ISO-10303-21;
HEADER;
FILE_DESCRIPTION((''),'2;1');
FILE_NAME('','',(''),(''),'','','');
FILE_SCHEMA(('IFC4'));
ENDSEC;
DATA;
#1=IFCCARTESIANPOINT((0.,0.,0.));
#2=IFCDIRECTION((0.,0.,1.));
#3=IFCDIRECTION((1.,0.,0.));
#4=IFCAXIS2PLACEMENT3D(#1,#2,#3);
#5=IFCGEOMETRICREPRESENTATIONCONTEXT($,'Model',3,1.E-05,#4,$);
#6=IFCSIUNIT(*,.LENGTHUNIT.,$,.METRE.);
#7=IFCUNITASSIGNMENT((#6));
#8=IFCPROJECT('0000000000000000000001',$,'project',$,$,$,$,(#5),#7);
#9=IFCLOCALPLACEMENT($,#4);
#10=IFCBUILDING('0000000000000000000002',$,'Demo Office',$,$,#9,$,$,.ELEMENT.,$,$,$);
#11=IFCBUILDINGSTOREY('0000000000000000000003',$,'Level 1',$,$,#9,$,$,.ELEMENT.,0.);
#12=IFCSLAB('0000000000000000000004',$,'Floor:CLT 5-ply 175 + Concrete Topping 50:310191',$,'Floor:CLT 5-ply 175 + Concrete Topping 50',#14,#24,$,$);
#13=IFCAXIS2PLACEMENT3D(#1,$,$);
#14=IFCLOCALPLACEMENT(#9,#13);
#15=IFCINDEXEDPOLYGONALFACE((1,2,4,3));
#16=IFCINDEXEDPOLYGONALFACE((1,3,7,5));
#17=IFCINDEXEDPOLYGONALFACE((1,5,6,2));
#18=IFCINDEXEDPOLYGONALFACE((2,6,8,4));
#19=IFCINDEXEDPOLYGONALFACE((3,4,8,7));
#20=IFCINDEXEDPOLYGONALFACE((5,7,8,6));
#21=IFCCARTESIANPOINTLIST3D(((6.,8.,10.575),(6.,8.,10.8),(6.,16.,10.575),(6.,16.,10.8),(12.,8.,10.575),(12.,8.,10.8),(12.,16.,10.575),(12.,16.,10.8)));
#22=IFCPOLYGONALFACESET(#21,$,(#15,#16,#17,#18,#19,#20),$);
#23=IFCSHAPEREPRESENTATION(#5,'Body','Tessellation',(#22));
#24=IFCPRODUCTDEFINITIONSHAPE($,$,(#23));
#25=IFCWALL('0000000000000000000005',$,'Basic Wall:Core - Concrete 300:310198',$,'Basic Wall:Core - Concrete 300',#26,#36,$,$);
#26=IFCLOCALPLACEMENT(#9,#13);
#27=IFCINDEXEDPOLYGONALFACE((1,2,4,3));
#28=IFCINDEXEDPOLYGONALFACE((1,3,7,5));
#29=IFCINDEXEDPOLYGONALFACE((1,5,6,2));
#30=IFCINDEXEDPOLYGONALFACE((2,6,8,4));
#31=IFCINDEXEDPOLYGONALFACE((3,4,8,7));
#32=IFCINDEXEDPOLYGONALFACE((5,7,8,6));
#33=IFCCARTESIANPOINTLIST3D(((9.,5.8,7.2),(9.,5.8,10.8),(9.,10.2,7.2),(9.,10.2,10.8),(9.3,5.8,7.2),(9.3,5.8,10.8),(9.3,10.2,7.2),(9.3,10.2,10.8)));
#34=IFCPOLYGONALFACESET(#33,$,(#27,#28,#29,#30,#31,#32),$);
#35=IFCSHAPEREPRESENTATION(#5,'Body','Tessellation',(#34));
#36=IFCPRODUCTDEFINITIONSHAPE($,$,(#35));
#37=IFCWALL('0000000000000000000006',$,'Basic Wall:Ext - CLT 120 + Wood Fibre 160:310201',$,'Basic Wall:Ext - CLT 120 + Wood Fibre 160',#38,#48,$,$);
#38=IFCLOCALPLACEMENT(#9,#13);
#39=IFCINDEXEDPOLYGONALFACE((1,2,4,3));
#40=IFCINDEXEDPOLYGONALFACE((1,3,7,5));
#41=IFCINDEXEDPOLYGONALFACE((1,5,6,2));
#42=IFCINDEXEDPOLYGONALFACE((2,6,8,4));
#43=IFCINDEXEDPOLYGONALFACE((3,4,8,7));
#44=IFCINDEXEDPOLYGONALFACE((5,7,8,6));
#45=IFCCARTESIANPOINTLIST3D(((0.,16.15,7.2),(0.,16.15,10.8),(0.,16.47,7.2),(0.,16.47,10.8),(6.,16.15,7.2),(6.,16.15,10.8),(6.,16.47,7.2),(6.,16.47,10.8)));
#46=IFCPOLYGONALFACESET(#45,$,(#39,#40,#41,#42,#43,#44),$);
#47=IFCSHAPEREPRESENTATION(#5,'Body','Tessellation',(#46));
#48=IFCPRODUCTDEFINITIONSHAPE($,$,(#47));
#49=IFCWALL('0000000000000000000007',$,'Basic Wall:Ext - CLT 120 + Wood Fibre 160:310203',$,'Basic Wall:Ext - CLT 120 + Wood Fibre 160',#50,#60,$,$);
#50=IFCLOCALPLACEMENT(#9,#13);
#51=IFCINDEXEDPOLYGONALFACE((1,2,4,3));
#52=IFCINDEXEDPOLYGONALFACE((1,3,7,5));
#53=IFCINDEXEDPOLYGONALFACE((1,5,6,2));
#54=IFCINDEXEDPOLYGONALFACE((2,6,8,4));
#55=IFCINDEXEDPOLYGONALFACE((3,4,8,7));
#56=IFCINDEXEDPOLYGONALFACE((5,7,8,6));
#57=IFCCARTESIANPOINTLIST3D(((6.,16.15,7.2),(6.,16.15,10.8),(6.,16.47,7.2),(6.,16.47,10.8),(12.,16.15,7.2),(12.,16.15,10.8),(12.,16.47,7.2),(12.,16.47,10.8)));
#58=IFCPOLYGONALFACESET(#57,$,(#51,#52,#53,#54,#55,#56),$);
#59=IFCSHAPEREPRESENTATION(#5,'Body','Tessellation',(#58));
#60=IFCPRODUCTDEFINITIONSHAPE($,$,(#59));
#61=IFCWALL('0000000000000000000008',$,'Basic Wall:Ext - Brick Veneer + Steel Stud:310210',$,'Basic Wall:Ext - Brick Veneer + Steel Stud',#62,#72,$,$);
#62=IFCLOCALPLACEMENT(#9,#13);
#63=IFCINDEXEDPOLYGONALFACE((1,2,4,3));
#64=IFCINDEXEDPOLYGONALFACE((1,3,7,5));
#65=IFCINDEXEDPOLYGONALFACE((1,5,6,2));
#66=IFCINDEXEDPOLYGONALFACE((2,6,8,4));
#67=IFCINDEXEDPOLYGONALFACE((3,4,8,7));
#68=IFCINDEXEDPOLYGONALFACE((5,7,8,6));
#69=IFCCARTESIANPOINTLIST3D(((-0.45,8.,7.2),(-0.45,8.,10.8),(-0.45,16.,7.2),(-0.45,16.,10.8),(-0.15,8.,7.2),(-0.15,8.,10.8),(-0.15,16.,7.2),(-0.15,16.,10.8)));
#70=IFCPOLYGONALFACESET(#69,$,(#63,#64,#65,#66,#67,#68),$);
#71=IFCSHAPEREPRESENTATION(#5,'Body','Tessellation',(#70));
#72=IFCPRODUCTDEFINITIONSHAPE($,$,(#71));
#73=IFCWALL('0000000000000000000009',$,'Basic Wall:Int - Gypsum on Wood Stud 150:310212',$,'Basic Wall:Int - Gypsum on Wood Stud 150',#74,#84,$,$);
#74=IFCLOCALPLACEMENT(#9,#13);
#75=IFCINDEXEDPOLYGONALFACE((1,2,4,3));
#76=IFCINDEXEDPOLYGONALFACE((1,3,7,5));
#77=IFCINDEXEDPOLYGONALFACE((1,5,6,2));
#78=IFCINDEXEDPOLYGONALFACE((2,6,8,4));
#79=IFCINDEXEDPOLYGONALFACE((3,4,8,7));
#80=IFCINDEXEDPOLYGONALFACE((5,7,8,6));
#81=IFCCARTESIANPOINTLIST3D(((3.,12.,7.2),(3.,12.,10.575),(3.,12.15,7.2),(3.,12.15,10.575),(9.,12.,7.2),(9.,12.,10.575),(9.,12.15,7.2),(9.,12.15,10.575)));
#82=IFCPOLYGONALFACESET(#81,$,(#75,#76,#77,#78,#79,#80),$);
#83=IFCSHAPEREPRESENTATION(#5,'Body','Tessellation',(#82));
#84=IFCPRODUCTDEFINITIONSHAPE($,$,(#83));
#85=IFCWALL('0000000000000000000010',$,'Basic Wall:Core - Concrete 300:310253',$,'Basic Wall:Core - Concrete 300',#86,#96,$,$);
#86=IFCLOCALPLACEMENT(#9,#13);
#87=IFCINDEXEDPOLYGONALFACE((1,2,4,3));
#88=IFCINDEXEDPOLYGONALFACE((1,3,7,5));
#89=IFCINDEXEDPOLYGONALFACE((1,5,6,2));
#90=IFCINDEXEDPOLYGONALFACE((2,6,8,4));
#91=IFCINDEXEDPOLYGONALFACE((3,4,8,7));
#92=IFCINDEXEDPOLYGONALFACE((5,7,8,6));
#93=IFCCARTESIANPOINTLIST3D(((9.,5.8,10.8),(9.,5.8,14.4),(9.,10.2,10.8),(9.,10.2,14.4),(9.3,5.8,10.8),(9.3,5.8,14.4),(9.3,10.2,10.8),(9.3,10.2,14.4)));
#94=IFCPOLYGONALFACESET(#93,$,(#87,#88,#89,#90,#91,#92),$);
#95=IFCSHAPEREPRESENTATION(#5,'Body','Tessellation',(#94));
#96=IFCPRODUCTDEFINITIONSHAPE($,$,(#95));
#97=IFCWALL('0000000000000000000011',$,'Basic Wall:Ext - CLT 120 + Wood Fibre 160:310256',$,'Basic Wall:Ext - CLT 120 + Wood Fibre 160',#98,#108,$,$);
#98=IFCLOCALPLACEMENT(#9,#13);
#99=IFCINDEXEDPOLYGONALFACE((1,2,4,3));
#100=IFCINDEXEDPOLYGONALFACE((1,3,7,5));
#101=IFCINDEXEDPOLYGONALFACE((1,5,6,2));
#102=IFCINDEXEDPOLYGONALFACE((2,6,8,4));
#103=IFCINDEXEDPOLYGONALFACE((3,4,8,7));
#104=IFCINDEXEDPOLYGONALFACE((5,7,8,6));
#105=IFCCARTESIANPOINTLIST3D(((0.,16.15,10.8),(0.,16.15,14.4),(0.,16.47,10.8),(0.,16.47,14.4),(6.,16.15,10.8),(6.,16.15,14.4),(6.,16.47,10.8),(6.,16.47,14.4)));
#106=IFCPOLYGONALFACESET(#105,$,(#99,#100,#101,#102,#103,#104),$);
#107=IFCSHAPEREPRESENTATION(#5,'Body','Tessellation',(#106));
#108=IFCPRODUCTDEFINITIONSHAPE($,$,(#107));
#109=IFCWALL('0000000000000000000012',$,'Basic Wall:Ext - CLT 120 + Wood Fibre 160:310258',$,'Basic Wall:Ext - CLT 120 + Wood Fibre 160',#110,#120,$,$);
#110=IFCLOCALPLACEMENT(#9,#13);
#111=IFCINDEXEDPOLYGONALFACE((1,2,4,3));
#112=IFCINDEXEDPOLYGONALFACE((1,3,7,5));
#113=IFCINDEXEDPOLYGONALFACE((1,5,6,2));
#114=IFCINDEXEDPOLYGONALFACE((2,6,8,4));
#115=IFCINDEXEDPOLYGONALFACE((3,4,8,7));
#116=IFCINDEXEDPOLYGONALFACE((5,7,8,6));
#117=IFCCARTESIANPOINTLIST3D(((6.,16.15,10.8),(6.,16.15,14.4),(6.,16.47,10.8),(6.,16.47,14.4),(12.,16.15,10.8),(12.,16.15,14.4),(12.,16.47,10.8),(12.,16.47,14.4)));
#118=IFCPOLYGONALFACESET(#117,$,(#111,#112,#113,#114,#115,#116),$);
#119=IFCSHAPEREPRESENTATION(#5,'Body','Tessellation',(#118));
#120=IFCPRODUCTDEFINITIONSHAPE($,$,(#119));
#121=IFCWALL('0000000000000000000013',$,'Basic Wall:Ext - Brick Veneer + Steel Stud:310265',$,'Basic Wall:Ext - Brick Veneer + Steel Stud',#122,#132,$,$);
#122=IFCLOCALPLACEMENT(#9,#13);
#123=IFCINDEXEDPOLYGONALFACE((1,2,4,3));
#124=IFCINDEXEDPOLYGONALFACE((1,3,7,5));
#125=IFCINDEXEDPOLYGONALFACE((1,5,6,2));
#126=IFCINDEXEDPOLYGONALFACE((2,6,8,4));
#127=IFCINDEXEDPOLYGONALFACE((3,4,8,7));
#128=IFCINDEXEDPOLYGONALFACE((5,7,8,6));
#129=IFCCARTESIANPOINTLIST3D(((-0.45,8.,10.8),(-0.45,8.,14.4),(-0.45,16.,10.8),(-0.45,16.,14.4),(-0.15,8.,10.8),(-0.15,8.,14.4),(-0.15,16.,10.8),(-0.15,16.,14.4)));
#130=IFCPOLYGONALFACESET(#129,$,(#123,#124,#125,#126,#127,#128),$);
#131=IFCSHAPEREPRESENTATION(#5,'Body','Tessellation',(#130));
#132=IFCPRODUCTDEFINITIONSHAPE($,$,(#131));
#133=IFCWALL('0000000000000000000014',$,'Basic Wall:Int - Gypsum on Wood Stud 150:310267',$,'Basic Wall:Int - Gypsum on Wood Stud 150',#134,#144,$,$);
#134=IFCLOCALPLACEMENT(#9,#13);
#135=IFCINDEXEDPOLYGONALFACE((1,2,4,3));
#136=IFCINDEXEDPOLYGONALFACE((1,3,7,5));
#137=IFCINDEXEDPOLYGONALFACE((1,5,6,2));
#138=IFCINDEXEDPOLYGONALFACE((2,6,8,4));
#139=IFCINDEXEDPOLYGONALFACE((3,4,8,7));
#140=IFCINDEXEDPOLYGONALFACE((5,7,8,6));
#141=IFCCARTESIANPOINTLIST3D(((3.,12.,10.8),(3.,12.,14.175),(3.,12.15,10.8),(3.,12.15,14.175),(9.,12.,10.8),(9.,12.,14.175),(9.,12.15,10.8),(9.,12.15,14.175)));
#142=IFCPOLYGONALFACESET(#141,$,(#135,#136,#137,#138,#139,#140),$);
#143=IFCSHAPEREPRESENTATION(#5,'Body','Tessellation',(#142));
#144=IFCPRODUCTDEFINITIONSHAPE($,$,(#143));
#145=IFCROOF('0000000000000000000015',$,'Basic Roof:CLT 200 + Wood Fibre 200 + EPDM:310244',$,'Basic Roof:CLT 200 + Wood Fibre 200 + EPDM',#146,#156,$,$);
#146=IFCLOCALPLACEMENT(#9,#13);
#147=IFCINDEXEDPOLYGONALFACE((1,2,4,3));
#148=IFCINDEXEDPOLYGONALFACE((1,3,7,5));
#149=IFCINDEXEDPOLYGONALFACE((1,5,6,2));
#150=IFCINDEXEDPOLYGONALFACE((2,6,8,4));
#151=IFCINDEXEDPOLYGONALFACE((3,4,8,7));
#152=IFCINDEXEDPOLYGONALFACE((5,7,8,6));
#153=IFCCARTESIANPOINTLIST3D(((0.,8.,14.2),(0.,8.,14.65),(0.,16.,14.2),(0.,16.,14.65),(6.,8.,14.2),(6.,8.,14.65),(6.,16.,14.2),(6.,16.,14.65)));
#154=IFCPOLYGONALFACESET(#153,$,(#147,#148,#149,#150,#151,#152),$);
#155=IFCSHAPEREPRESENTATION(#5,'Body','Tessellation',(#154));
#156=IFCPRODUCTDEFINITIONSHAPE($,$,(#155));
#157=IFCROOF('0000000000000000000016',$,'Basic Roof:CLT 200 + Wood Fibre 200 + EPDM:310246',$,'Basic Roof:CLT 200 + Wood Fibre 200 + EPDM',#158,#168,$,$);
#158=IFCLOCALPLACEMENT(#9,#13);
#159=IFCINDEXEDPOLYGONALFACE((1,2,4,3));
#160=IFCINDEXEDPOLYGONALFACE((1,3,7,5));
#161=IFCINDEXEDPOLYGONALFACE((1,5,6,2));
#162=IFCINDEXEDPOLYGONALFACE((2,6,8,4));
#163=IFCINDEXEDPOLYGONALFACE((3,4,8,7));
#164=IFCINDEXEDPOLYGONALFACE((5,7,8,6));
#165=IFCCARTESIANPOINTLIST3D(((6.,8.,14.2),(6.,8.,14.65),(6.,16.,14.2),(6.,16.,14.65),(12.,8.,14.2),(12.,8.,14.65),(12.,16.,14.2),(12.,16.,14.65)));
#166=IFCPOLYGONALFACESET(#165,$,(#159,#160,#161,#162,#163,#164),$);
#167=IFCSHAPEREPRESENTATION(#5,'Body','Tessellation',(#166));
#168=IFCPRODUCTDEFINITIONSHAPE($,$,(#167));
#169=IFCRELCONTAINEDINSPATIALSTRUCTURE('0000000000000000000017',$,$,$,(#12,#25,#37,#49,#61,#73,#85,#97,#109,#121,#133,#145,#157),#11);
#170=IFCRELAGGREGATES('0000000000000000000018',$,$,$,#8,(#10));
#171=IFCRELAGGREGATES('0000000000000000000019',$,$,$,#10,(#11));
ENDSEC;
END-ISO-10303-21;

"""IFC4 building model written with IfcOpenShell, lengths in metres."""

from ifc_helpers import new_model, si_unit, frame, origin_with_axes, origin_2d, place, context, project, spatial, rectangle, extrude, element, save


model = new_model("IFC4")

# Units and contexts
model_context = context("Model", 3, precision=1e-05, world=origin_with_axes())
ifc_project = project(units=[si_unit("LENGTHUNIT", "METRE")], contexts=[model_context])

# Building, storey
placement = place(None, origin_with_axes())
building = spatial("IfcBuilding", under=ifc_project, at=placement, Name="Demo Office", CompositionType="ELEMENT")
storey = spatial("IfcBuildingStorey", under=building, at=placement, Name="Level 1", CompositionType="ELEMENT", Elevation=0.0)

# Slab
for number, where, name in (
    (1, (9.0, 12.0, 10.575), "Floor:CLT 5-ply 175 + Concrete Topping 50:310191"),
):
    element("IfcSlab", number, at=place(placement, frame(where)), inside=storey, Name=name, ObjectType="Floor:CLT 5-ply 175 + Concrete Topping 50", context=model_context, shape_type="SweptSolid", body=[
        extrude(rectangle(XDim=6.0, YDim=8.0, at=origin_2d()), origin_with_axes(), (0.0, 0.0, 1.0), 0.225),
    ])

# Walls
wall_1_placement = place(placement, frame((9.15, 8.0, 7.2)))
element("IfcWall", 2, at=wall_1_placement, inside=storey, Name="Basic Wall:Core - Concrete 300:310198", ObjectType="Basic Wall:Core - Concrete 300", context=model_context, shape_type="SweptSolid", body=[
    extrude(rectangle(XDim=0.3, YDim=4.4, at=origin_2d()), origin_with_axes(), (0.0, 0.0, 1.0), 3.6),
])
for number, where, name in (
    (3, (3.0, 16.31, 7.2), "Basic Wall:Ext - CLT 120 + Wood Fibre 160:310201"),
    (4, (9.0, 16.31, 7.2), "Basic Wall:Ext - CLT 120 + Wood Fibre 160:310203"),
):
    element("IfcWall", number, at=place(placement, frame(where)), inside=storey, Name=name, ObjectType="Basic Wall:Ext - CLT 120 + Wood Fibre 160", context=model_context, shape_type="SweptSolid", body=[
        extrude(rectangle(XDim=6.0, YDim=0.32, at=origin_2d()), origin_with_axes(), (0.0, 0.0, 1.0), 3.6),
    ])
wall_2_placement = place(placement, frame((-0.3, 12.0, 7.2)))
element("IfcWall", 5, at=wall_2_placement, inside=storey, Name="Basic Wall:Ext - Brick Veneer + Steel Stud:310210", ObjectType="Basic Wall:Ext - Brick Veneer + Steel Stud", context=model_context, shape_type="SweptSolid", body=[
    extrude(rectangle(XDim=0.3, YDim=8.0, at=origin_2d()), origin_with_axes(), (0.0, 0.0, 1.0), 3.6),
])
wall_3_placement = place(placement, frame((6.0, 12.075, 7.2)))
element("IfcWall", 6, at=wall_3_placement, inside=storey, Name="Basic Wall:Int - Gypsum on Wood Stud 150:310212", ObjectType="Basic Wall:Int - Gypsum on Wood Stud 150", context=model_context, shape_type="SweptSolid", body=[
    extrude(rectangle(XDim=6.0, YDim=0.15, at=origin_2d()), origin_with_axes(), (0.0, 0.0, 1.0), 3.375),
])
wall_4_placement = place(placement, frame((9.15, 8.0, 10.8)))
element("IfcWall", 7, at=wall_4_placement, inside=storey, Name="Basic Wall:Core - Concrete 300:310253", ObjectType="Basic Wall:Core - Concrete 300", context=model_context, shape_type="SweptSolid", body=[
    extrude(rectangle(XDim=0.3, YDim=4.4, at=origin_2d()), origin_with_axes(), (0.0, 0.0, 1.0), 3.6),
])
for number, where, name in (
    (8, (3.0, 16.31, 10.8), "Basic Wall:Ext - CLT 120 + Wood Fibre 160:310256"),
    (9, (9.0, 16.31, 10.8), "Basic Wall:Ext - CLT 120 + Wood Fibre 160:310258"),
):
    element("IfcWall", number, at=place(placement, frame(where)), inside=storey, Name=name, ObjectType="Basic Wall:Ext - CLT 120 + Wood Fibre 160", context=model_context, shape_type="SweptSolid", body=[
        extrude(rectangle(XDim=6.0, YDim=0.32, at=origin_2d()), origin_with_axes(), (0.0, 0.0, 1.0), 3.6),
    ])
wall_5_placement = place(placement, frame((-0.3, 12.0, 10.8)))
element("IfcWall", 10, at=wall_5_placement, inside=storey, Name="Basic Wall:Ext - Brick Veneer + Steel Stud:310265", ObjectType="Basic Wall:Ext - Brick Veneer + Steel Stud", context=model_context, shape_type="SweptSolid", body=[
    extrude(rectangle(XDim=0.3, YDim=8.0, at=origin_2d()), origin_with_axes(), (0.0, 0.0, 1.0), 3.6),
])
wall_6_placement = place(placement, frame((6.0, 12.075, 10.8)))
element("IfcWall", 11, at=wall_6_placement, inside=storey, Name="Basic Wall:Int - Gypsum on Wood Stud 150:310267", ObjectType="Basic Wall:Int - Gypsum on Wood Stud 150", context=model_context, shape_type="SweptSolid", body=[
    extrude(rectangle(XDim=6.0, YDim=0.15, at=origin_2d()), origin_with_axes(), (0.0, 0.0, 1.0), 3.375),
])

# Roofs
for number, where, name in (
    (12, (3.0, 12.0, 14.2), "Basic Roof:CLT 200 + Wood Fibre 200 + EPDM:310244"),
    (13, (9.0, 12.0, 14.2), "Basic Roof:CLT 200 + Wood Fibre 200 + EPDM:310246"),
):
    element("IfcRoof", number, at=place(placement, frame(where)), inside=storey, Name=name, ObjectType="Basic Roof:CLT 200 + Wood Fibre 200 + EPDM", context=model_context, shape_type="SweptSolid", body=[
        extrude(rectangle(XDim=6.0, YDim=8.0, at=origin_2d()), origin_with_axes(), (0.0, 0.0, 1.0), 0.45),
    ])

save(model, "model.ifc")
